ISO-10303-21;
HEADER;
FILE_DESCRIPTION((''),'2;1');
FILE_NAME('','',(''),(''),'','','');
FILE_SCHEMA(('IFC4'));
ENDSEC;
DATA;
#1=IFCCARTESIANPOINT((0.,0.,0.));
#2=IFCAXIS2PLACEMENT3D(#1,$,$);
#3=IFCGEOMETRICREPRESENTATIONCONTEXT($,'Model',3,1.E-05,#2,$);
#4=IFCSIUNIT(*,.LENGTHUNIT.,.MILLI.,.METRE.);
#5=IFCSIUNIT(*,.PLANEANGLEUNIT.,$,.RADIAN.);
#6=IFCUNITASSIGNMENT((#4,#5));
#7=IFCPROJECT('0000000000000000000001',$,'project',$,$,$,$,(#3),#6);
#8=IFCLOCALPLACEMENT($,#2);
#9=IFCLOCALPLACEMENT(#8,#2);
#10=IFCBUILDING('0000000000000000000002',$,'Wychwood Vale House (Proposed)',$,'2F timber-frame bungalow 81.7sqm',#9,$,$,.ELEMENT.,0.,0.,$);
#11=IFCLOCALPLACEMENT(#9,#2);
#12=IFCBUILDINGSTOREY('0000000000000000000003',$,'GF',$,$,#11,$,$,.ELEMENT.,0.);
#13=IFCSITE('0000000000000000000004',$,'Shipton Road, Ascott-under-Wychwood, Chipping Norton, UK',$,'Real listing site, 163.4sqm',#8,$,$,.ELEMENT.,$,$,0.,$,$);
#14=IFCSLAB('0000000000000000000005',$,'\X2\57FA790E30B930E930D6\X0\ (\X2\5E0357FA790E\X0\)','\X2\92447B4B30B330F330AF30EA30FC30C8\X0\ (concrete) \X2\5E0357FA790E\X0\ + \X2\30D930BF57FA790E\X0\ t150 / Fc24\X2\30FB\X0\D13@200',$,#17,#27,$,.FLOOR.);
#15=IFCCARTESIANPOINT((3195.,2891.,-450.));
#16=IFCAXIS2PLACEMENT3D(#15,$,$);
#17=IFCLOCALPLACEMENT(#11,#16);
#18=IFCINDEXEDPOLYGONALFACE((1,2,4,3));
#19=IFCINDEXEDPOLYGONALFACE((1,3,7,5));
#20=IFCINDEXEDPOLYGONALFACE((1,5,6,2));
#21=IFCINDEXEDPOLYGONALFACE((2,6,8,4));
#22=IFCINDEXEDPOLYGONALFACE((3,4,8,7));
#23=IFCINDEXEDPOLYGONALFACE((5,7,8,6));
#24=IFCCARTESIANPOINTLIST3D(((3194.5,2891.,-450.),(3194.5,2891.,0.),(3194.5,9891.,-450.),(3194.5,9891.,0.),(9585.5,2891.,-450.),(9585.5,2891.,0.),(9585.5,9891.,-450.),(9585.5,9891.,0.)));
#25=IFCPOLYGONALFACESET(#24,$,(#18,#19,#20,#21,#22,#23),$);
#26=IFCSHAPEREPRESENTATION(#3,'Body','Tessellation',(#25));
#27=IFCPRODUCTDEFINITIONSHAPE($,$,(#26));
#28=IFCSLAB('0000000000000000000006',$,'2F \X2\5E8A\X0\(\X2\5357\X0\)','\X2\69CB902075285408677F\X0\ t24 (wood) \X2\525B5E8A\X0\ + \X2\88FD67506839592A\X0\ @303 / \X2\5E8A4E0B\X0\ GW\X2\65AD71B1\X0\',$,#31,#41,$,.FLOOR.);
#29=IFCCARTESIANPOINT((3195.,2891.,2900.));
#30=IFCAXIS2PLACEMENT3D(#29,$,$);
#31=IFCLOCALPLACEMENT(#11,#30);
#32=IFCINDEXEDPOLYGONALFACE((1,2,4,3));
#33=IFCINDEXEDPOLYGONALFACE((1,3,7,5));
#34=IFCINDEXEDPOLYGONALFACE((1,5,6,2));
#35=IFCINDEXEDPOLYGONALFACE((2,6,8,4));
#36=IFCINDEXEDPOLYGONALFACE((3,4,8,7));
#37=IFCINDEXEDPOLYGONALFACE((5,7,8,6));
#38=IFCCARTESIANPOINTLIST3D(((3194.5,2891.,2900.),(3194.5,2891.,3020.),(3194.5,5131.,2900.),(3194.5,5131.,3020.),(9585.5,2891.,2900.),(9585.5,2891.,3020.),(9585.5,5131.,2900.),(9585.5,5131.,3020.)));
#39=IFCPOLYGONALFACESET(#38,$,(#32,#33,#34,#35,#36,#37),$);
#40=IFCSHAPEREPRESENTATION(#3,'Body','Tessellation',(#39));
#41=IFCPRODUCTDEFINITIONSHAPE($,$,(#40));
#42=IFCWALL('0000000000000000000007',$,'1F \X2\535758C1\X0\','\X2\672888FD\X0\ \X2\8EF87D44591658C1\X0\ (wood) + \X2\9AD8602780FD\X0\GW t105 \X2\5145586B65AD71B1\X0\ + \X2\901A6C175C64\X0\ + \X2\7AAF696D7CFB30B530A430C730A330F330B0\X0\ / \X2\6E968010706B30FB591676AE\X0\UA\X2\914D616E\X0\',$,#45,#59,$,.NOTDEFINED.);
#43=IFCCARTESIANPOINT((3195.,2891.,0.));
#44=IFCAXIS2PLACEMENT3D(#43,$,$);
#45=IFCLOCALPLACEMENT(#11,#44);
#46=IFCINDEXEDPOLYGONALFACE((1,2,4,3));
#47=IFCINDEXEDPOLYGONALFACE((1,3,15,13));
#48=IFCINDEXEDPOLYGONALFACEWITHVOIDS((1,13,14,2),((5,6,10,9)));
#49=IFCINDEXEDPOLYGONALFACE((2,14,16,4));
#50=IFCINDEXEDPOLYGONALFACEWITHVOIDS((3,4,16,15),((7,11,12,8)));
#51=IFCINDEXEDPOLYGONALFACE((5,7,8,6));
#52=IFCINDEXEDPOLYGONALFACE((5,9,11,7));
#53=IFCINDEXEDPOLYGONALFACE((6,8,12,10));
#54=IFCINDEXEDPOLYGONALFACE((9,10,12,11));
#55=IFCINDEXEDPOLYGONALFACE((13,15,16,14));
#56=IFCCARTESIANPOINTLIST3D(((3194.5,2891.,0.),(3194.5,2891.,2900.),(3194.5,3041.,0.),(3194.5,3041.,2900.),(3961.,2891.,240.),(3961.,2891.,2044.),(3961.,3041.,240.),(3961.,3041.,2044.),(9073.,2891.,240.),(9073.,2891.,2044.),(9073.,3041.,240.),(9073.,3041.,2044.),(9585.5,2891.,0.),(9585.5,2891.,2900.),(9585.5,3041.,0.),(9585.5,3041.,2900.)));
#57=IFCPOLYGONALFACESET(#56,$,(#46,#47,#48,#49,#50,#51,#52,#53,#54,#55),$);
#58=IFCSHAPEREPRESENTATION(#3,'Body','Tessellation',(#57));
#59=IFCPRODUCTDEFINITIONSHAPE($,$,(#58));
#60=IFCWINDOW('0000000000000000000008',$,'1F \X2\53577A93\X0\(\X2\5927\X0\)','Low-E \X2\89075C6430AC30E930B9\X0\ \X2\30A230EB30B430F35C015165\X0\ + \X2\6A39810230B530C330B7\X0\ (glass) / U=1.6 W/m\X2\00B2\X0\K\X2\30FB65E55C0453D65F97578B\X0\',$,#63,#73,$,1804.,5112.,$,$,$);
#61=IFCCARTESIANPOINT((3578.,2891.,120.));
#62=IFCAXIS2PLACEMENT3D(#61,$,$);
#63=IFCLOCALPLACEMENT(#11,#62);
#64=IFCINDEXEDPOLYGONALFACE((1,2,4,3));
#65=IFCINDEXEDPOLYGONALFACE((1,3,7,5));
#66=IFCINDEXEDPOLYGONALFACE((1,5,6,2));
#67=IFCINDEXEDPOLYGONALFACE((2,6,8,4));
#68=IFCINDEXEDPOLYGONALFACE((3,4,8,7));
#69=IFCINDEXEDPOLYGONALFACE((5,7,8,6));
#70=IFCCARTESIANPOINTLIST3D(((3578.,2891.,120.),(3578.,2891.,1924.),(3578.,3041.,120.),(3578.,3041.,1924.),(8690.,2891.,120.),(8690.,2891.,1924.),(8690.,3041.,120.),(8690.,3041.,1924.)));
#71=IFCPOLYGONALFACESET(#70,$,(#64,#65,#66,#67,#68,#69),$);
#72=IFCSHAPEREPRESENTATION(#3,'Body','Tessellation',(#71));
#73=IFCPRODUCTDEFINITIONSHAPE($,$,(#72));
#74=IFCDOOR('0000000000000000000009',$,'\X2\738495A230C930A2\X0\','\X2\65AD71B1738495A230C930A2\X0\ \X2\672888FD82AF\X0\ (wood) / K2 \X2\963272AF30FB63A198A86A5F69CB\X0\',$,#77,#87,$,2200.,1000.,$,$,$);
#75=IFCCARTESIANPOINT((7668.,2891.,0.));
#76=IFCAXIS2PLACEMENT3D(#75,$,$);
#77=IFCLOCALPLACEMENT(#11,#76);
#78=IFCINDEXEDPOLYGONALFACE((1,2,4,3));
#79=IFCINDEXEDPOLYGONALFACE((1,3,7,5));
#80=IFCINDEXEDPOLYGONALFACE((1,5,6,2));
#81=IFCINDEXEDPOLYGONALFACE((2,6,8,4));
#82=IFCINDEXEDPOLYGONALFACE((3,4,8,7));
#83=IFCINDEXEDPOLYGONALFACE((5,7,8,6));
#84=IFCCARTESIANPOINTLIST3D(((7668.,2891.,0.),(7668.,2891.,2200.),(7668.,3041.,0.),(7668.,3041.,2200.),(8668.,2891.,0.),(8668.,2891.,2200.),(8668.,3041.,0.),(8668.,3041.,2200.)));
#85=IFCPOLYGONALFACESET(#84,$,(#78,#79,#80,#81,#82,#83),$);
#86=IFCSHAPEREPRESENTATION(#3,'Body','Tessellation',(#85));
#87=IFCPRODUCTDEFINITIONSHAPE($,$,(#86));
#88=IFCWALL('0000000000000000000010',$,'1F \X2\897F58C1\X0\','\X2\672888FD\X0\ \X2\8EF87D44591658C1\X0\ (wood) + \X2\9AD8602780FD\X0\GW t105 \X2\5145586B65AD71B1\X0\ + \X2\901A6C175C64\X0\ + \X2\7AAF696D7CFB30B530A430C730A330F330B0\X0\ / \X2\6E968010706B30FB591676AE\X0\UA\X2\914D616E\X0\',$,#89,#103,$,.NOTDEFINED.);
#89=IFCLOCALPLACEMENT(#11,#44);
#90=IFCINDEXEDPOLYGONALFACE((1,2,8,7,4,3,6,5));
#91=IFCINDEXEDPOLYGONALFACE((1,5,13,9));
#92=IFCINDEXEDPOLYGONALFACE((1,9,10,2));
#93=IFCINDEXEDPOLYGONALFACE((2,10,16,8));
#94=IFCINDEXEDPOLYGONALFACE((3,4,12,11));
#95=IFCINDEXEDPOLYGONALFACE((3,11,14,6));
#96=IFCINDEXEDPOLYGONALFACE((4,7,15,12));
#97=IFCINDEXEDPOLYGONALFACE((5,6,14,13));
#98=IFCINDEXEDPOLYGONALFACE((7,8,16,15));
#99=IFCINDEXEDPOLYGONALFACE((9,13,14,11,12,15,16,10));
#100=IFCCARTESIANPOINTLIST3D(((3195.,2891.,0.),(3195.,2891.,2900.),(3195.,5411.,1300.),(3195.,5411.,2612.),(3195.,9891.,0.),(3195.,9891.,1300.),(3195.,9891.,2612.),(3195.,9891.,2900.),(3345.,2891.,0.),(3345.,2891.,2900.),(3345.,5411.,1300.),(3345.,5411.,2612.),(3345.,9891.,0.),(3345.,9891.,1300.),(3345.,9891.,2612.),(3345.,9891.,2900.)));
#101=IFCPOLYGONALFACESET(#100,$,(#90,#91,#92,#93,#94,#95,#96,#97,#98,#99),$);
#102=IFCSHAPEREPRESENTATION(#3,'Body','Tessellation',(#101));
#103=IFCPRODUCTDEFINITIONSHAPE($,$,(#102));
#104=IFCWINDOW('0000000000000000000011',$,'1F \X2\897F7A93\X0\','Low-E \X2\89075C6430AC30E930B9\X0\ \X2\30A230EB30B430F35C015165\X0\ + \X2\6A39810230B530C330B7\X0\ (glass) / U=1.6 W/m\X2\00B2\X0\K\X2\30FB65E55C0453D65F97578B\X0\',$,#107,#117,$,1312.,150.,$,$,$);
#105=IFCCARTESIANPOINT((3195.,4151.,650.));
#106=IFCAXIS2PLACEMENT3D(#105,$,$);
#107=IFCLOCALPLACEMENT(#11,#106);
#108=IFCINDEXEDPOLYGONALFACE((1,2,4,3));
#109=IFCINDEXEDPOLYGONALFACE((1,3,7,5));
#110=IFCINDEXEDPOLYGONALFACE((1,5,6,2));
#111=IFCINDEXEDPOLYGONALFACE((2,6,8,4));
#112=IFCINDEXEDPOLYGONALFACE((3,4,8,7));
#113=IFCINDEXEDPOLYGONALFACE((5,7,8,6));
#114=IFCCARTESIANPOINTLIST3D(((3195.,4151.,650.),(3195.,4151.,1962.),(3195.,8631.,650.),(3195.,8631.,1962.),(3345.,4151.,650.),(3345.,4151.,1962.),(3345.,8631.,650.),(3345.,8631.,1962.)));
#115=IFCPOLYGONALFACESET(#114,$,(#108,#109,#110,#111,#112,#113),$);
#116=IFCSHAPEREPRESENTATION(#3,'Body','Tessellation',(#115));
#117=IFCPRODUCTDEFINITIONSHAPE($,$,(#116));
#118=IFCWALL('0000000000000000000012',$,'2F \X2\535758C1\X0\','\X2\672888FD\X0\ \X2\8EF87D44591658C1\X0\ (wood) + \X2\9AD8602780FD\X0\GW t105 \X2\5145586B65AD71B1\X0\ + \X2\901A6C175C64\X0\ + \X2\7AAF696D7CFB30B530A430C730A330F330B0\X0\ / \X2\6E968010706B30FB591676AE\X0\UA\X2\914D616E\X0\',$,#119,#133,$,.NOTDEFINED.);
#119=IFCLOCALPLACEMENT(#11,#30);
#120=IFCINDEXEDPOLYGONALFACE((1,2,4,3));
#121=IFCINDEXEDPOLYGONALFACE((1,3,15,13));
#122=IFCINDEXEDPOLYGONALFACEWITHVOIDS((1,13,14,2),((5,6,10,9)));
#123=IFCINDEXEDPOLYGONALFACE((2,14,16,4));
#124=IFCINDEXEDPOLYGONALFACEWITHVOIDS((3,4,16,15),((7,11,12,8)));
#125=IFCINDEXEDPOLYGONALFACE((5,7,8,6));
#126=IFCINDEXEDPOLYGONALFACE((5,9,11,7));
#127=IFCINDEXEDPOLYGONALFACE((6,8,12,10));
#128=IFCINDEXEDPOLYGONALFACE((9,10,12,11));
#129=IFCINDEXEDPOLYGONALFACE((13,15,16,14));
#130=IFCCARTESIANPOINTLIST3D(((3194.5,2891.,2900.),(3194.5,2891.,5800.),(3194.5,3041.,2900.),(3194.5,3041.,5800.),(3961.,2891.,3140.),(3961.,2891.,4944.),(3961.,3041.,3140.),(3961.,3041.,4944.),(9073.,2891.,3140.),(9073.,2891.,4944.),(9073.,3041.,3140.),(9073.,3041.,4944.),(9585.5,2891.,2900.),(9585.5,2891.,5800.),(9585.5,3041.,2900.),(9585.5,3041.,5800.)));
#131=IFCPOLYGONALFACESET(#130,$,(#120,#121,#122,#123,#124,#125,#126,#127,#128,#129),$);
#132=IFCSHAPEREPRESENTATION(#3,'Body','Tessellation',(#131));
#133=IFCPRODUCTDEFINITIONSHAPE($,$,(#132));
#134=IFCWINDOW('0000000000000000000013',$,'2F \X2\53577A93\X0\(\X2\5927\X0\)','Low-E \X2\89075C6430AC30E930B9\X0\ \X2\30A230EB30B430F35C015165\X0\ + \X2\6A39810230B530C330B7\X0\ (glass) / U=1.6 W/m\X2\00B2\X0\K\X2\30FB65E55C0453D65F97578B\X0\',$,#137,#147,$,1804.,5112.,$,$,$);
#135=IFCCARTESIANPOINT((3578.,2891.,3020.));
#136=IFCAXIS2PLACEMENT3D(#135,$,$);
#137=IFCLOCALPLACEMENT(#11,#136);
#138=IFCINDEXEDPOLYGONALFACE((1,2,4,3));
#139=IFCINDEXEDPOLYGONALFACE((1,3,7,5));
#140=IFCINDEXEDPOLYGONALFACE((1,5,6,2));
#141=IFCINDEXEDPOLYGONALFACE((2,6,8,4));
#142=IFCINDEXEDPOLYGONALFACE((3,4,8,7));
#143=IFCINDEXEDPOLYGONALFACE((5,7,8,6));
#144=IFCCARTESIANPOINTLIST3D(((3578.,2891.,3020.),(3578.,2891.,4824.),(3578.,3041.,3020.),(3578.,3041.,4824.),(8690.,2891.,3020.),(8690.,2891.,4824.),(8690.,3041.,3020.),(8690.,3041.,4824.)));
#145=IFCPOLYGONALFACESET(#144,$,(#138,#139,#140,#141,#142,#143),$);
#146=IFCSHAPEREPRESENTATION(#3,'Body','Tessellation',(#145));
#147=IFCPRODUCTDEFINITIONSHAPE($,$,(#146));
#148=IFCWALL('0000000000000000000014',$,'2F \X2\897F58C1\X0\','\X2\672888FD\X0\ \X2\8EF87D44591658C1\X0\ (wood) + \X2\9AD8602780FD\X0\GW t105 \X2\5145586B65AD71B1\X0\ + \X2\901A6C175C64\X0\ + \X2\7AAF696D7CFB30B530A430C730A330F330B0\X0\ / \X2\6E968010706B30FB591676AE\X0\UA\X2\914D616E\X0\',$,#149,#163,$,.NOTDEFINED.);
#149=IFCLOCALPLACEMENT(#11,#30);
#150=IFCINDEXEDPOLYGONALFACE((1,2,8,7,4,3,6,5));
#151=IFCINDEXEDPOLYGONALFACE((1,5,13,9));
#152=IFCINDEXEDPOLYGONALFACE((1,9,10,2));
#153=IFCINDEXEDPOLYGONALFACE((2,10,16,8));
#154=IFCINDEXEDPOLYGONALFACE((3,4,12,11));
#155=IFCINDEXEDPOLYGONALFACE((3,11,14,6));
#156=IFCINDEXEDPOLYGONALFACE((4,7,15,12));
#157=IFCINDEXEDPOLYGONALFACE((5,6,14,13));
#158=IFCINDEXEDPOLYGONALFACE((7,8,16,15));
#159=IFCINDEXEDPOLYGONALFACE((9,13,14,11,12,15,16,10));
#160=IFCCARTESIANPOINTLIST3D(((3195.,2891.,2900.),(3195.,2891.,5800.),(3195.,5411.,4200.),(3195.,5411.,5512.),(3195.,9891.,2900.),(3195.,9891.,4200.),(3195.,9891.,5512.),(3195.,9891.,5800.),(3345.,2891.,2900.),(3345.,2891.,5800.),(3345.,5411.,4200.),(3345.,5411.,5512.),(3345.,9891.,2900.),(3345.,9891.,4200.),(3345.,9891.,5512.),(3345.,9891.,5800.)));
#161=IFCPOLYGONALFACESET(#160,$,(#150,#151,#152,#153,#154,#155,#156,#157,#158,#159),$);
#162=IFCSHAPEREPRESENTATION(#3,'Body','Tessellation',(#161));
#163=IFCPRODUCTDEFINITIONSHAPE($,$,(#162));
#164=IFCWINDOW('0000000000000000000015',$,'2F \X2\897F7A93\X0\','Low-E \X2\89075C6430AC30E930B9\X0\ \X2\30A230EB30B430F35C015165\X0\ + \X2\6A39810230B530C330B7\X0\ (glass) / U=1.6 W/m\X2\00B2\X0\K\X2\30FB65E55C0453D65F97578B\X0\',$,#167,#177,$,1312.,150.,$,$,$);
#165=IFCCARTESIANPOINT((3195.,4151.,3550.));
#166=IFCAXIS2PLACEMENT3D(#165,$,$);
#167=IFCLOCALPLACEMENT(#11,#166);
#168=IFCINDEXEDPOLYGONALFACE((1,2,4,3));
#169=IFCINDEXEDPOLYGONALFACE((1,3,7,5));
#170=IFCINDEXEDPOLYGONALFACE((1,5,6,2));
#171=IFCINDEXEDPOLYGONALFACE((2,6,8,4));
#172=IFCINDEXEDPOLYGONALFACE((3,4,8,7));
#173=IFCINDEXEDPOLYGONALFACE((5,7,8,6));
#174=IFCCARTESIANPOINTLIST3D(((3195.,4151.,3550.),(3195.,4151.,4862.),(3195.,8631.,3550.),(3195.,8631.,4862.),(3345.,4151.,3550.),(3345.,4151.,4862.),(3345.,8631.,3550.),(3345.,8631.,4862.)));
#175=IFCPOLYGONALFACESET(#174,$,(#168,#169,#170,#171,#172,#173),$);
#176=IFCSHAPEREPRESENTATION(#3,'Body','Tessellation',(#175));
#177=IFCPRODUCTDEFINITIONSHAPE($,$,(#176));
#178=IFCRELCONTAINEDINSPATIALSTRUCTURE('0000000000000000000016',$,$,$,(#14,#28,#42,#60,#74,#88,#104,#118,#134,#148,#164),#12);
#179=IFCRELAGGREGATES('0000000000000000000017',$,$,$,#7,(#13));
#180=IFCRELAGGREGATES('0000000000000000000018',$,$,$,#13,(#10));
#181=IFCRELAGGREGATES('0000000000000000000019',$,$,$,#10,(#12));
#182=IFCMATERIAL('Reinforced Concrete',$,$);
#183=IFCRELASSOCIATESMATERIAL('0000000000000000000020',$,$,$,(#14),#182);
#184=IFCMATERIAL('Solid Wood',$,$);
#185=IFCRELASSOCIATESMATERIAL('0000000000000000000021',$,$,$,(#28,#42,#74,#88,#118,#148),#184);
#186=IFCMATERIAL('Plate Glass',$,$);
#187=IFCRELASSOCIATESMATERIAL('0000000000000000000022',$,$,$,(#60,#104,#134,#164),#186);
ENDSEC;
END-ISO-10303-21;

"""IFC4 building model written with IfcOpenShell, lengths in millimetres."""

from ifc_helpers import new_model, si_unit, frame, frame_2d, origin, place, context, project, spatial, rectangle, extrude, material, element, fill, save


model = new_model("IFC4")

# Units and contexts
model_context = context("Model", 3, precision=1e-05, world=origin())
ifc_project = project(units=[si_unit("LENGTHUNIT", "METRE", prefix="MILLI"), si_unit("PLANEANGLEUNIT", "RADIAN")], contexts=[model_context])

# Site, building, storey
site_placement = place(None, origin())
site = spatial("IfcSite", under=ifc_project, at=site_placement, Name="Shipton Road, Ascott-under-Wychwood, Chipping Norton, UK", ObjectType="Real listing site, 163.4sqm", CompositionType="ELEMENT", RefElevation=0.0)
building_placement = place(site_placement, origin())
building = spatial("IfcBuilding", under=site, at=building_placement, Name="Wychwood Vale House (Proposed)", ObjectType="2F timber-frame bungalow 81.7sqm", CompositionType="ELEMENT", ElevationOfRefHeight=0.0, ElevationOfTerrain=0.0)
storey_placement = place(building_placement, origin())
storey = spatial("IfcBuildingStorey", under=building, at=storey_placement, Name="GF", CompositionType="ELEMENT", Elevation=0.0)

# Slabs
ifc_material_1 = material(Name="Reinforced Concrete")
slab_1_placement = place(storey_placement, frame((3195.0, 2891.0, -450.0)))
element("IfcSlab", 1, at=slab_1_placement, inside=storey, material=ifc_material_1, Name="基礎スラブ (布基礎)", Description="鉄筋コンクリート (concrete) 布基礎 + ベタ基礎 t150 / Fc24・D13@200", PredefinedType="FLOOR", context=model_context, shape_type="SweptSolid", body=[
    extrude(rectangle(XDim=6391.0, YDim=7000.0, at=frame_2d((3195.0, 3500.0))), frame((3195.0, 2891.0, -450.0)), (0.0, 0.0, 1.0), 450.0),
])
ifc_material_2 = material(Name="Solid Wood")
slab_2_placement = place(storey_placement, frame((3195.0, 2891.0, 2900.0)))
element("IfcSlab", 2, at=slab_2_placement, inside=storey, material=ifc_material_2, Name="2F 床(南)", Description="構造用合板 t24 (wood) 剛床 + 製材根太 @303 / 床下 GW断熱", PredefinedType="FLOOR", context=model_context, shape_type="SweptSolid", body=[
    extrude(rectangle(XDim=6391.0, YDim=2240.0, at=frame_2d((3195.0, 1120.0))), frame((3195.0, 2891.0, 2900.0)), (0.0, 0.0, 1.0), 120.0),
])

# Wall, openings, window, door
wall_1_placement = place(storey_placement, frame((3195.0, 2891.0, 0.0)))
wall_1 = element("IfcWall", 3, at=wall_1_placement, inside=storey, material=ifc_material_2, Name="1F 南壁", Description="木製 軸組外壁 (wood) + 高性能GW t105 充填断熱 + 通気層 + 窯業系サイディング / 準耐火・外皮UA配慮", PredefinedType="NOTDEFINED", context=model_context, shape_type="SweptSolid", body=[
    extrude(rectangle(XDim=6391.0, YDim=150.0, at=frame_2d((3195.0, 75.0))), frame((3195.0, 2891.0, 0.0)), (0.0, 0.0, 1.0), 2900.0),
])
opening_1_placement = place(storey_placement, frame((3578.0, 2891.0, 120.0)))
opening_1 = element("IfcOpeningElement", 4, at=opening_1_placement, cuts=wall_1, PredefinedType="NOTDEFINED", context=model_context, shape_type="SweptSolid", body=[
    extrude(rectangle(XDim=5112.0, YDim=150.0, at=frame_2d((2556.0, 75.0))), frame((3578.0, 2891.0, 120.0)), (0.0, 0.0, 1.0), 1804.0),
])
opening_2_placement = place(storey_placement, frame((7668.0, 2891.0, 0.0)))
opening_2 = element("IfcOpeningElement", 5, at=opening_2_placement, cuts=wall_1, PredefinedType="NOTDEFINED", context=model_context, shape_type="SweptSolid", body=[
    extrude(rectangle(XDim=1000.0, YDim=150.0, at=frame_2d((500.0, 75.0))), frame((7668.0, 2891.0, 0.0)), (0.0, 0.0, 1.0), 2200.0),
])
ifc_material_3 = material(Name="Plate Glass")
window_1_placement = place(storey_placement, frame((3578.0, 2891.0, 120.0)))
window_1 = element("IfcWindow", 6, at=window_1_placement, inside=storey, material=ifc_material_3, Name="1F 南窓(大)", Description="Low-E 複層ガラス アルゴン封入 + 樹脂サッシ (glass) / U=1.6 W/m²K・日射取得型", OverallHeight=1804.0, OverallWidth=5112.0, context=model_context, shape_type="SweptSolid", body=[
    extrude(rectangle(XDim=5112.0, YDim=150.0, at=frame_2d((2556.0, 75.0))), frame((3578.0, 2891.0, 120.0)), (0.0, 0.0, 1.0), 1804.0),
])
fill(opening_1, window_1)
door_placement = place(storey_placement, frame((7668.0, 2891.0, 0.0)))
door = element("IfcDoor", 7, at=door_placement, inside=storey, material=ifc_material_2, Name="玄関ドア", Description="断熱玄関ドア 木製芯 (wood) / K2 防犯・採風機構", OverallHeight=2200.0, OverallWidth=1000.0, context=model_context, shape_type="SweptSolid", body=[
    extrude(rectangle(XDim=1000.0, YDim=150.0, at=frame_2d((500.0, 75.0))), frame((7668.0, 2891.0, 0.0)), (0.0, 0.0, 1.0), 2200.0),
])
fill(opening_2, door)

# Walls, openings, windows
wall_2_placement = place(storey_placement, frame((3195.0, 2891.0, 0.0)))
wall_2 = element("IfcWall", 8, at=wall_2_placement, inside=storey, material=ifc_material_2, Name="1F 西壁", Description="木製 軸組外壁 (wood) + 高性能GW t105 充填断熱 + 通気層 + 窯業系サイディング / 準耐火・外皮UA配慮", PredefinedType="NOTDEFINED", context=model_context, shape_type="SweptSolid", body=[
    extrude(rectangle(XDim=150.0, YDim=7000.0, at=frame_2d((75.0, 3500.0))), frame((3195.0, 2891.0, 0.0)), (0.0, 0.0, 1.0), 2900.0),
])
opening_3_placement = place(storey_placement, frame((3195.0, 4151.0, 650.0)))
opening_3 = element("IfcOpeningElement", 9, at=opening_3_placement, cuts=wall_2, PredefinedType="NOTDEFINED", context=model_context, shape_type="SweptSolid", body=[
    extrude(rectangle(XDim=150.0, YDim=4480.0, at=frame_2d((75.0, 2240.0))), frame((3195.0, 4151.0, 650.0)), (0.0, 0.0, 1.0), 1312.0),
])
window_2_placement = place(storey_placement, frame((3195.0, 4151.0, 650.0)))
window_2 = element("IfcWindow", 10, at=window_2_placement, inside=storey, material=ifc_material_3, Name="1F 西窓", Description="Low-E 複層ガラス アルゴン封入 + 樹脂サッシ (glass) / U=1.6 W/m²K・日射取得型", OverallHeight=1312.0, OverallWidth=150.0, context=model_context, shape_type="SweptSolid", body=[
    extrude(rectangle(XDim=150.0, YDim=4480.0, at=frame_2d((75.0, 2240.0))), frame((3195.0, 4151.0, 650.0)), (0.0, 0.0, 1.0), 1312.0),
])
fill(opening_3, window_2)
wall_3_placement = place(storey_placement, frame((3195.0, 2891.0, 2900.0)))
wall_3 = element("IfcWall", 11, at=wall_3_placement, inside=storey, material=ifc_material_2, Name="2F 南壁", Description="木製 軸組外壁 (wood) + 高性能GW t105 充填断熱 + 通気層 + 窯業系サイディング / 準耐火・外皮UA配慮", PredefinedType="NOTDEFINED", context=model_context, shape_type="SweptSolid", body=[
    extrude(rectangle(XDim=6391.0, YDim=150.0, at=frame_2d((3195.0, 75.0))), frame((3195.0, 2891.0, 2900.0)), (0.0, 0.0, 1.0), 2900.0),
])
opening_4_placement = place(storey_placement, frame((3578.0, 2891.0, 3020.0)))
opening_4 = element("IfcOpeningElement", 12, at=opening_4_placement, cuts=wall_3, PredefinedType="NOTDEFINED", context=model_context, shape_type="SweptSolid", body=[
    extrude(rectangle(XDim=5112.0, YDim=150.0, at=frame_2d((2556.0, 75.0))), frame((3578.0, 2891.0, 3020.0)), (0.0, 0.0, 1.0), 1804.0),
])
window_3_placement = place(storey_placement, frame((3578.0, 2891.0, 3020.0)))
window_3 = element("IfcWindow", 13, at=window_3_placement, inside=storey, material=ifc_material_3, Name="2F 南窓(大)", Description="Low-E 複層ガラス アルゴン封入 + 樹脂サッシ (glass) / U=1.6 W/m²K・日射取得型", OverallHeight=1804.0, OverallWidth=5112.0, context=model_context, shape_type="SweptSolid", body=[
    extrude(rectangle(XDim=5112.0, YDim=150.0, at=frame_2d((2556.0, 75.0))), frame((3578.0, 2891.0, 3020.0)), (0.0, 0.0, 1.0), 1804.0),
])
fill(opening_4, window_3)
wall_4_placement = place(storey_placement, frame((3195.0, 2891.0, 2900.0)))
wall_4 = element("IfcWall", 14, at=wall_4_placement, inside=storey, material=ifc_material_2, Name="2F 西壁", Description="木製 軸組外壁 (wood) + 高性能GW t105 充填断熱 + 通気層 + 窯業系サイディング / 準耐火・外皮UA配慮", PredefinedType="NOTDEFINED", context=model_context, shape_type="SweptSolid", body=[
    extrude(rectangle(XDim=150.0, YDim=7000.0, at=frame_2d((75.0, 3500.0))), frame((3195.0, 2891.0, 2900.0)), (0.0, 0.0, 1.0), 2900.0),
])
opening_5_placement = place(storey_placement, frame((3195.0, 4151.0, 3550.0)))
opening_5 = element("IfcOpeningElement", 15, at=opening_5_placement, cuts=wall_4, PredefinedType="NOTDEFINED", context=model_context, shape_type="SweptSolid", body=[
    extrude(rectangle(XDim=150.0, YDim=4480.0, at=frame_2d((75.0, 2240.0))), frame((3195.0, 4151.0, 3550.0)), (0.0, 0.0, 1.0), 1312.0),
])
window_4_placement = place(storey_placement, frame((3195.0, 4151.0, 3550.0)))
window_4 = element("IfcWindow", 16, at=window_4_placement, inside=storey, material=ifc_material_3, Name="2F 西窓", Description="Low-E 複層ガラス アルゴン封入 + 樹脂サッシ (glass) / U=1.6 W/m²K・日射取得型", OverallHeight=1312.0, OverallWidth=150.0, context=model_context, shape_type="SweptSolid", body=[
    extrude(rectangle(XDim=150.0, YDim=4480.0, at=frame_2d((75.0, 2240.0))), frame((3195.0, 4151.0, 3550.0)), (0.0, 0.0, 1.0), 1312.0),
])
fill(opening_5, window_4)

save(model, "model.ifc")
